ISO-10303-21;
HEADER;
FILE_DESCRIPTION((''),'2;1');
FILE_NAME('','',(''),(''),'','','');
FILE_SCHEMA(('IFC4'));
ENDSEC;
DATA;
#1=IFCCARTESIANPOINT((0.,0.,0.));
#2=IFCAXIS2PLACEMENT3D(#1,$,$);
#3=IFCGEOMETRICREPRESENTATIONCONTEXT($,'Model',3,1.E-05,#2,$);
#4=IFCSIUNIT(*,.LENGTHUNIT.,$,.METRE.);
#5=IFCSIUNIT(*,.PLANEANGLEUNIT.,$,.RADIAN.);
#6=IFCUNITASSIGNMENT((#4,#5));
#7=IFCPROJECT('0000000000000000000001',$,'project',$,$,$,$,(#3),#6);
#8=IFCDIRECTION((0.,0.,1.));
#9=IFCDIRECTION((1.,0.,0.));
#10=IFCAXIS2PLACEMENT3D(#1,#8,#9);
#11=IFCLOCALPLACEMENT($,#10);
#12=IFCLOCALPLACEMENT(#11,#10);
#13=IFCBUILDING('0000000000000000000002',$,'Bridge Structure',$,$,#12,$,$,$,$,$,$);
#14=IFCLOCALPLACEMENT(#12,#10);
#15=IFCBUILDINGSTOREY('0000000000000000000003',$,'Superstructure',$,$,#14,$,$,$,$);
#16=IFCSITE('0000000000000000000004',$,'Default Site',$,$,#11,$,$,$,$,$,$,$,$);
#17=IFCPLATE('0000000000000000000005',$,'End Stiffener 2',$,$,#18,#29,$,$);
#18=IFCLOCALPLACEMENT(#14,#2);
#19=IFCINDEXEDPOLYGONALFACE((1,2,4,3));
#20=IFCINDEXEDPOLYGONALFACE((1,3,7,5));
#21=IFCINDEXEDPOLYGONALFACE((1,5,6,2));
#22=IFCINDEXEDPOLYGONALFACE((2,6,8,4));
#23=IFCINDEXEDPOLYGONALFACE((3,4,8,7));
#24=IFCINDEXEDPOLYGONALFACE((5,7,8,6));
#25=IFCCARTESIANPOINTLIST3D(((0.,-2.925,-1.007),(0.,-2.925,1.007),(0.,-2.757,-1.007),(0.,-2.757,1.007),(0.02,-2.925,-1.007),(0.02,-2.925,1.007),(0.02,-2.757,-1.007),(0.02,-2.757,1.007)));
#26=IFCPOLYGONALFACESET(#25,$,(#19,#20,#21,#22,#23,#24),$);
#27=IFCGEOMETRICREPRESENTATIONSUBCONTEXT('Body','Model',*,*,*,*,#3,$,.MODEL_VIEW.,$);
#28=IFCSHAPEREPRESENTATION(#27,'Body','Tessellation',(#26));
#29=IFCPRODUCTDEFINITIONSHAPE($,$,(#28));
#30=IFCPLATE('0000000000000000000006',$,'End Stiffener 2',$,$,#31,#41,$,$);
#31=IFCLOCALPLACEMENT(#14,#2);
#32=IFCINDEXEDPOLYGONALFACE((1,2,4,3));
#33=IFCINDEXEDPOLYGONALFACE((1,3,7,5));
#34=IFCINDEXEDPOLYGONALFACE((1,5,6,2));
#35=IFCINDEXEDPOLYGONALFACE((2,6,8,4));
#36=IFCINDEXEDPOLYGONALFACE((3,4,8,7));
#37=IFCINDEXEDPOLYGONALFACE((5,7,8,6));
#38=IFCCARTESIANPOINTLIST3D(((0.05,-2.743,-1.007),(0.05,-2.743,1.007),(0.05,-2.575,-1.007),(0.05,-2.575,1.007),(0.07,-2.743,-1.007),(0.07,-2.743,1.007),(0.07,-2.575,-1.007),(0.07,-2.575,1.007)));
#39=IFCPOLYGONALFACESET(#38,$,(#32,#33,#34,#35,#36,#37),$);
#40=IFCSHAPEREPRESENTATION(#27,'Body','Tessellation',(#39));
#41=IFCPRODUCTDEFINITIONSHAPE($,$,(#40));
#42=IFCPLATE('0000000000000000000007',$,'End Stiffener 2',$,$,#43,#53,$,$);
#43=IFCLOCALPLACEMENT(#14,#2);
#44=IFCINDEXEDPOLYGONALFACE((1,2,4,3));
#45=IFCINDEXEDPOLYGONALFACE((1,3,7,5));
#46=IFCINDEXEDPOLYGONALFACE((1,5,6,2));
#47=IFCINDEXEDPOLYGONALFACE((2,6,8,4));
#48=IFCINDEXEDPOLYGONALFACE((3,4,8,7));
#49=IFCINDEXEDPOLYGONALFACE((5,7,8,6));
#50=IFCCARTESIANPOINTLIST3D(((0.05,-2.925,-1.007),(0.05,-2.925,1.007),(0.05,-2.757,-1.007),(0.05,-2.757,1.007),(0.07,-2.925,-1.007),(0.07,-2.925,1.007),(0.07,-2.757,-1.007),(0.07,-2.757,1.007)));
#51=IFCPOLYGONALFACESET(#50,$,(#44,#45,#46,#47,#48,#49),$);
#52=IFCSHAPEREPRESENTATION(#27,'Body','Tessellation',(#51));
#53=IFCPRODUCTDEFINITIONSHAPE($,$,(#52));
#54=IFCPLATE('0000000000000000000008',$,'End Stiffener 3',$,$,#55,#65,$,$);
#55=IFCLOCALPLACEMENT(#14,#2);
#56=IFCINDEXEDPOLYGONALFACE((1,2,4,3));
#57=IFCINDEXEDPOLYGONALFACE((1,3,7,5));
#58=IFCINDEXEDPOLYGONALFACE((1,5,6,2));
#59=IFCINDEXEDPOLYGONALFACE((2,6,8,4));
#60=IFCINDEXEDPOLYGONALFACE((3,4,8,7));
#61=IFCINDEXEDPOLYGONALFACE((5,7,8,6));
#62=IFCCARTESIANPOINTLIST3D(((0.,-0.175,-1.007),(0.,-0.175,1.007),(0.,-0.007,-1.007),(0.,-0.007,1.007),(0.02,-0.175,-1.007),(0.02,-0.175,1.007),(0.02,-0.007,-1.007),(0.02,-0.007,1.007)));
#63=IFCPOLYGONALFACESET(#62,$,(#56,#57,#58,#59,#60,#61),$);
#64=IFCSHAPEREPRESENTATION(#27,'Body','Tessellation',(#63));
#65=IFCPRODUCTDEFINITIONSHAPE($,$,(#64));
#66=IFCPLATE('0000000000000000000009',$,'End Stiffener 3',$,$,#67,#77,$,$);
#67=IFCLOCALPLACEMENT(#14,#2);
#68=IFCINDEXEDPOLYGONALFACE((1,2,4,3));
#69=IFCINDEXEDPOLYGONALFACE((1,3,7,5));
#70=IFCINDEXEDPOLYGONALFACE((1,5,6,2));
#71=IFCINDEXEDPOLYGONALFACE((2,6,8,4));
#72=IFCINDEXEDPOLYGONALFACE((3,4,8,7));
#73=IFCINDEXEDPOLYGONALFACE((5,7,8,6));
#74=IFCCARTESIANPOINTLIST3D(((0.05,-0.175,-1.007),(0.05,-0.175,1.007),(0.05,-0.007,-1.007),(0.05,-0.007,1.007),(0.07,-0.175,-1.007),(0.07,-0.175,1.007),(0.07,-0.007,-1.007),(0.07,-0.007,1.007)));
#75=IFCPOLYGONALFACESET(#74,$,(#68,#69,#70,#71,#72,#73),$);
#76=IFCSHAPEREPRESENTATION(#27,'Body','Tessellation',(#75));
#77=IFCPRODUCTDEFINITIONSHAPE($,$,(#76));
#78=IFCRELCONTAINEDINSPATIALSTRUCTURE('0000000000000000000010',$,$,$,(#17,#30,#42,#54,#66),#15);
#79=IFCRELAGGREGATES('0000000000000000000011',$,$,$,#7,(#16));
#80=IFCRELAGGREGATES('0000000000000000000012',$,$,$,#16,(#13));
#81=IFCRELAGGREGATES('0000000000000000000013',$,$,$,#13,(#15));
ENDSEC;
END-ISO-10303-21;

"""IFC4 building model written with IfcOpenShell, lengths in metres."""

from ifc_helpers import new_model, si_unit, frame, origin, origin_with_axes, origin_2d_with_axis, place, context, subcontext, project, spatial, rectangle, extrude, element, save


model = new_model("IFC4")

# Units and contexts
model_context = context("Model", 3, precision=1e-05, world=origin())
body_context = subcontext(model_context, "Body", "Model", "MODEL_VIEW")
ifc_project = project(units=[si_unit("LENGTHUNIT", "METRE"), si_unit("PLANEANGLEUNIT", "RADIAN")], contexts=[model_context])

# Site, building, storey
site_placement = place(None, origin_with_axes())
site = spatial("IfcSite", under=ifc_project, at=site_placement, Name="Default Site")
building_placement = place(site_placement, origin_with_axes())
building = spatial("IfcBuilding", under=site, at=building_placement, Name="Bridge Structure")
storey_placement = place(building_placement, origin_with_axes())
storey = spatial("IfcBuildingStorey", under=building, at=storey_placement, Name="Superstructure")

# Plates
for number, where, z_axis, x_axis, name in (
    (1, (0.01, -2.841, -1.007), (0.0, 0.0, 1.0), (1.0, 0.0, 0.0), "End Stiffener 2"),
    (2, (0.06, -2.659, -1.007), (0.0, 0.0, 1.0), (1.0, 0.0, 0.0), "End Stiffener 2"),
    (3, (0.06, -2.841, -1.007), (0.0, 0.0, 1.0), (1.0, 0.0, 0.0), "End Stiffener 2"),
    (4, (0.01, -0.091, -1.007), (0.0, 0.0, 1.0), (1.0, 0.0, 0.0), "End Stiffener 3"),
    (5, (0.06, -0.091, -1.007), (0.0, 0.0, 1.0), (1.0, 0.0, 0.0), "End Stiffener 3"),
):
    element("IfcPlate", number, at=place(storey_placement, frame(where, z_axis=z_axis, x_axis=x_axis)), inside=storey, Name=name, context=body_context, shape_type="SweptSolid", body=[
        extrude(rectangle(XDim=0.02, YDim=0.168, at=origin_2d_with_axis()), origin_with_axes(), (0.0, 0.0, 1.0), 2.014),
    ])

save(model, "model.ifc")
